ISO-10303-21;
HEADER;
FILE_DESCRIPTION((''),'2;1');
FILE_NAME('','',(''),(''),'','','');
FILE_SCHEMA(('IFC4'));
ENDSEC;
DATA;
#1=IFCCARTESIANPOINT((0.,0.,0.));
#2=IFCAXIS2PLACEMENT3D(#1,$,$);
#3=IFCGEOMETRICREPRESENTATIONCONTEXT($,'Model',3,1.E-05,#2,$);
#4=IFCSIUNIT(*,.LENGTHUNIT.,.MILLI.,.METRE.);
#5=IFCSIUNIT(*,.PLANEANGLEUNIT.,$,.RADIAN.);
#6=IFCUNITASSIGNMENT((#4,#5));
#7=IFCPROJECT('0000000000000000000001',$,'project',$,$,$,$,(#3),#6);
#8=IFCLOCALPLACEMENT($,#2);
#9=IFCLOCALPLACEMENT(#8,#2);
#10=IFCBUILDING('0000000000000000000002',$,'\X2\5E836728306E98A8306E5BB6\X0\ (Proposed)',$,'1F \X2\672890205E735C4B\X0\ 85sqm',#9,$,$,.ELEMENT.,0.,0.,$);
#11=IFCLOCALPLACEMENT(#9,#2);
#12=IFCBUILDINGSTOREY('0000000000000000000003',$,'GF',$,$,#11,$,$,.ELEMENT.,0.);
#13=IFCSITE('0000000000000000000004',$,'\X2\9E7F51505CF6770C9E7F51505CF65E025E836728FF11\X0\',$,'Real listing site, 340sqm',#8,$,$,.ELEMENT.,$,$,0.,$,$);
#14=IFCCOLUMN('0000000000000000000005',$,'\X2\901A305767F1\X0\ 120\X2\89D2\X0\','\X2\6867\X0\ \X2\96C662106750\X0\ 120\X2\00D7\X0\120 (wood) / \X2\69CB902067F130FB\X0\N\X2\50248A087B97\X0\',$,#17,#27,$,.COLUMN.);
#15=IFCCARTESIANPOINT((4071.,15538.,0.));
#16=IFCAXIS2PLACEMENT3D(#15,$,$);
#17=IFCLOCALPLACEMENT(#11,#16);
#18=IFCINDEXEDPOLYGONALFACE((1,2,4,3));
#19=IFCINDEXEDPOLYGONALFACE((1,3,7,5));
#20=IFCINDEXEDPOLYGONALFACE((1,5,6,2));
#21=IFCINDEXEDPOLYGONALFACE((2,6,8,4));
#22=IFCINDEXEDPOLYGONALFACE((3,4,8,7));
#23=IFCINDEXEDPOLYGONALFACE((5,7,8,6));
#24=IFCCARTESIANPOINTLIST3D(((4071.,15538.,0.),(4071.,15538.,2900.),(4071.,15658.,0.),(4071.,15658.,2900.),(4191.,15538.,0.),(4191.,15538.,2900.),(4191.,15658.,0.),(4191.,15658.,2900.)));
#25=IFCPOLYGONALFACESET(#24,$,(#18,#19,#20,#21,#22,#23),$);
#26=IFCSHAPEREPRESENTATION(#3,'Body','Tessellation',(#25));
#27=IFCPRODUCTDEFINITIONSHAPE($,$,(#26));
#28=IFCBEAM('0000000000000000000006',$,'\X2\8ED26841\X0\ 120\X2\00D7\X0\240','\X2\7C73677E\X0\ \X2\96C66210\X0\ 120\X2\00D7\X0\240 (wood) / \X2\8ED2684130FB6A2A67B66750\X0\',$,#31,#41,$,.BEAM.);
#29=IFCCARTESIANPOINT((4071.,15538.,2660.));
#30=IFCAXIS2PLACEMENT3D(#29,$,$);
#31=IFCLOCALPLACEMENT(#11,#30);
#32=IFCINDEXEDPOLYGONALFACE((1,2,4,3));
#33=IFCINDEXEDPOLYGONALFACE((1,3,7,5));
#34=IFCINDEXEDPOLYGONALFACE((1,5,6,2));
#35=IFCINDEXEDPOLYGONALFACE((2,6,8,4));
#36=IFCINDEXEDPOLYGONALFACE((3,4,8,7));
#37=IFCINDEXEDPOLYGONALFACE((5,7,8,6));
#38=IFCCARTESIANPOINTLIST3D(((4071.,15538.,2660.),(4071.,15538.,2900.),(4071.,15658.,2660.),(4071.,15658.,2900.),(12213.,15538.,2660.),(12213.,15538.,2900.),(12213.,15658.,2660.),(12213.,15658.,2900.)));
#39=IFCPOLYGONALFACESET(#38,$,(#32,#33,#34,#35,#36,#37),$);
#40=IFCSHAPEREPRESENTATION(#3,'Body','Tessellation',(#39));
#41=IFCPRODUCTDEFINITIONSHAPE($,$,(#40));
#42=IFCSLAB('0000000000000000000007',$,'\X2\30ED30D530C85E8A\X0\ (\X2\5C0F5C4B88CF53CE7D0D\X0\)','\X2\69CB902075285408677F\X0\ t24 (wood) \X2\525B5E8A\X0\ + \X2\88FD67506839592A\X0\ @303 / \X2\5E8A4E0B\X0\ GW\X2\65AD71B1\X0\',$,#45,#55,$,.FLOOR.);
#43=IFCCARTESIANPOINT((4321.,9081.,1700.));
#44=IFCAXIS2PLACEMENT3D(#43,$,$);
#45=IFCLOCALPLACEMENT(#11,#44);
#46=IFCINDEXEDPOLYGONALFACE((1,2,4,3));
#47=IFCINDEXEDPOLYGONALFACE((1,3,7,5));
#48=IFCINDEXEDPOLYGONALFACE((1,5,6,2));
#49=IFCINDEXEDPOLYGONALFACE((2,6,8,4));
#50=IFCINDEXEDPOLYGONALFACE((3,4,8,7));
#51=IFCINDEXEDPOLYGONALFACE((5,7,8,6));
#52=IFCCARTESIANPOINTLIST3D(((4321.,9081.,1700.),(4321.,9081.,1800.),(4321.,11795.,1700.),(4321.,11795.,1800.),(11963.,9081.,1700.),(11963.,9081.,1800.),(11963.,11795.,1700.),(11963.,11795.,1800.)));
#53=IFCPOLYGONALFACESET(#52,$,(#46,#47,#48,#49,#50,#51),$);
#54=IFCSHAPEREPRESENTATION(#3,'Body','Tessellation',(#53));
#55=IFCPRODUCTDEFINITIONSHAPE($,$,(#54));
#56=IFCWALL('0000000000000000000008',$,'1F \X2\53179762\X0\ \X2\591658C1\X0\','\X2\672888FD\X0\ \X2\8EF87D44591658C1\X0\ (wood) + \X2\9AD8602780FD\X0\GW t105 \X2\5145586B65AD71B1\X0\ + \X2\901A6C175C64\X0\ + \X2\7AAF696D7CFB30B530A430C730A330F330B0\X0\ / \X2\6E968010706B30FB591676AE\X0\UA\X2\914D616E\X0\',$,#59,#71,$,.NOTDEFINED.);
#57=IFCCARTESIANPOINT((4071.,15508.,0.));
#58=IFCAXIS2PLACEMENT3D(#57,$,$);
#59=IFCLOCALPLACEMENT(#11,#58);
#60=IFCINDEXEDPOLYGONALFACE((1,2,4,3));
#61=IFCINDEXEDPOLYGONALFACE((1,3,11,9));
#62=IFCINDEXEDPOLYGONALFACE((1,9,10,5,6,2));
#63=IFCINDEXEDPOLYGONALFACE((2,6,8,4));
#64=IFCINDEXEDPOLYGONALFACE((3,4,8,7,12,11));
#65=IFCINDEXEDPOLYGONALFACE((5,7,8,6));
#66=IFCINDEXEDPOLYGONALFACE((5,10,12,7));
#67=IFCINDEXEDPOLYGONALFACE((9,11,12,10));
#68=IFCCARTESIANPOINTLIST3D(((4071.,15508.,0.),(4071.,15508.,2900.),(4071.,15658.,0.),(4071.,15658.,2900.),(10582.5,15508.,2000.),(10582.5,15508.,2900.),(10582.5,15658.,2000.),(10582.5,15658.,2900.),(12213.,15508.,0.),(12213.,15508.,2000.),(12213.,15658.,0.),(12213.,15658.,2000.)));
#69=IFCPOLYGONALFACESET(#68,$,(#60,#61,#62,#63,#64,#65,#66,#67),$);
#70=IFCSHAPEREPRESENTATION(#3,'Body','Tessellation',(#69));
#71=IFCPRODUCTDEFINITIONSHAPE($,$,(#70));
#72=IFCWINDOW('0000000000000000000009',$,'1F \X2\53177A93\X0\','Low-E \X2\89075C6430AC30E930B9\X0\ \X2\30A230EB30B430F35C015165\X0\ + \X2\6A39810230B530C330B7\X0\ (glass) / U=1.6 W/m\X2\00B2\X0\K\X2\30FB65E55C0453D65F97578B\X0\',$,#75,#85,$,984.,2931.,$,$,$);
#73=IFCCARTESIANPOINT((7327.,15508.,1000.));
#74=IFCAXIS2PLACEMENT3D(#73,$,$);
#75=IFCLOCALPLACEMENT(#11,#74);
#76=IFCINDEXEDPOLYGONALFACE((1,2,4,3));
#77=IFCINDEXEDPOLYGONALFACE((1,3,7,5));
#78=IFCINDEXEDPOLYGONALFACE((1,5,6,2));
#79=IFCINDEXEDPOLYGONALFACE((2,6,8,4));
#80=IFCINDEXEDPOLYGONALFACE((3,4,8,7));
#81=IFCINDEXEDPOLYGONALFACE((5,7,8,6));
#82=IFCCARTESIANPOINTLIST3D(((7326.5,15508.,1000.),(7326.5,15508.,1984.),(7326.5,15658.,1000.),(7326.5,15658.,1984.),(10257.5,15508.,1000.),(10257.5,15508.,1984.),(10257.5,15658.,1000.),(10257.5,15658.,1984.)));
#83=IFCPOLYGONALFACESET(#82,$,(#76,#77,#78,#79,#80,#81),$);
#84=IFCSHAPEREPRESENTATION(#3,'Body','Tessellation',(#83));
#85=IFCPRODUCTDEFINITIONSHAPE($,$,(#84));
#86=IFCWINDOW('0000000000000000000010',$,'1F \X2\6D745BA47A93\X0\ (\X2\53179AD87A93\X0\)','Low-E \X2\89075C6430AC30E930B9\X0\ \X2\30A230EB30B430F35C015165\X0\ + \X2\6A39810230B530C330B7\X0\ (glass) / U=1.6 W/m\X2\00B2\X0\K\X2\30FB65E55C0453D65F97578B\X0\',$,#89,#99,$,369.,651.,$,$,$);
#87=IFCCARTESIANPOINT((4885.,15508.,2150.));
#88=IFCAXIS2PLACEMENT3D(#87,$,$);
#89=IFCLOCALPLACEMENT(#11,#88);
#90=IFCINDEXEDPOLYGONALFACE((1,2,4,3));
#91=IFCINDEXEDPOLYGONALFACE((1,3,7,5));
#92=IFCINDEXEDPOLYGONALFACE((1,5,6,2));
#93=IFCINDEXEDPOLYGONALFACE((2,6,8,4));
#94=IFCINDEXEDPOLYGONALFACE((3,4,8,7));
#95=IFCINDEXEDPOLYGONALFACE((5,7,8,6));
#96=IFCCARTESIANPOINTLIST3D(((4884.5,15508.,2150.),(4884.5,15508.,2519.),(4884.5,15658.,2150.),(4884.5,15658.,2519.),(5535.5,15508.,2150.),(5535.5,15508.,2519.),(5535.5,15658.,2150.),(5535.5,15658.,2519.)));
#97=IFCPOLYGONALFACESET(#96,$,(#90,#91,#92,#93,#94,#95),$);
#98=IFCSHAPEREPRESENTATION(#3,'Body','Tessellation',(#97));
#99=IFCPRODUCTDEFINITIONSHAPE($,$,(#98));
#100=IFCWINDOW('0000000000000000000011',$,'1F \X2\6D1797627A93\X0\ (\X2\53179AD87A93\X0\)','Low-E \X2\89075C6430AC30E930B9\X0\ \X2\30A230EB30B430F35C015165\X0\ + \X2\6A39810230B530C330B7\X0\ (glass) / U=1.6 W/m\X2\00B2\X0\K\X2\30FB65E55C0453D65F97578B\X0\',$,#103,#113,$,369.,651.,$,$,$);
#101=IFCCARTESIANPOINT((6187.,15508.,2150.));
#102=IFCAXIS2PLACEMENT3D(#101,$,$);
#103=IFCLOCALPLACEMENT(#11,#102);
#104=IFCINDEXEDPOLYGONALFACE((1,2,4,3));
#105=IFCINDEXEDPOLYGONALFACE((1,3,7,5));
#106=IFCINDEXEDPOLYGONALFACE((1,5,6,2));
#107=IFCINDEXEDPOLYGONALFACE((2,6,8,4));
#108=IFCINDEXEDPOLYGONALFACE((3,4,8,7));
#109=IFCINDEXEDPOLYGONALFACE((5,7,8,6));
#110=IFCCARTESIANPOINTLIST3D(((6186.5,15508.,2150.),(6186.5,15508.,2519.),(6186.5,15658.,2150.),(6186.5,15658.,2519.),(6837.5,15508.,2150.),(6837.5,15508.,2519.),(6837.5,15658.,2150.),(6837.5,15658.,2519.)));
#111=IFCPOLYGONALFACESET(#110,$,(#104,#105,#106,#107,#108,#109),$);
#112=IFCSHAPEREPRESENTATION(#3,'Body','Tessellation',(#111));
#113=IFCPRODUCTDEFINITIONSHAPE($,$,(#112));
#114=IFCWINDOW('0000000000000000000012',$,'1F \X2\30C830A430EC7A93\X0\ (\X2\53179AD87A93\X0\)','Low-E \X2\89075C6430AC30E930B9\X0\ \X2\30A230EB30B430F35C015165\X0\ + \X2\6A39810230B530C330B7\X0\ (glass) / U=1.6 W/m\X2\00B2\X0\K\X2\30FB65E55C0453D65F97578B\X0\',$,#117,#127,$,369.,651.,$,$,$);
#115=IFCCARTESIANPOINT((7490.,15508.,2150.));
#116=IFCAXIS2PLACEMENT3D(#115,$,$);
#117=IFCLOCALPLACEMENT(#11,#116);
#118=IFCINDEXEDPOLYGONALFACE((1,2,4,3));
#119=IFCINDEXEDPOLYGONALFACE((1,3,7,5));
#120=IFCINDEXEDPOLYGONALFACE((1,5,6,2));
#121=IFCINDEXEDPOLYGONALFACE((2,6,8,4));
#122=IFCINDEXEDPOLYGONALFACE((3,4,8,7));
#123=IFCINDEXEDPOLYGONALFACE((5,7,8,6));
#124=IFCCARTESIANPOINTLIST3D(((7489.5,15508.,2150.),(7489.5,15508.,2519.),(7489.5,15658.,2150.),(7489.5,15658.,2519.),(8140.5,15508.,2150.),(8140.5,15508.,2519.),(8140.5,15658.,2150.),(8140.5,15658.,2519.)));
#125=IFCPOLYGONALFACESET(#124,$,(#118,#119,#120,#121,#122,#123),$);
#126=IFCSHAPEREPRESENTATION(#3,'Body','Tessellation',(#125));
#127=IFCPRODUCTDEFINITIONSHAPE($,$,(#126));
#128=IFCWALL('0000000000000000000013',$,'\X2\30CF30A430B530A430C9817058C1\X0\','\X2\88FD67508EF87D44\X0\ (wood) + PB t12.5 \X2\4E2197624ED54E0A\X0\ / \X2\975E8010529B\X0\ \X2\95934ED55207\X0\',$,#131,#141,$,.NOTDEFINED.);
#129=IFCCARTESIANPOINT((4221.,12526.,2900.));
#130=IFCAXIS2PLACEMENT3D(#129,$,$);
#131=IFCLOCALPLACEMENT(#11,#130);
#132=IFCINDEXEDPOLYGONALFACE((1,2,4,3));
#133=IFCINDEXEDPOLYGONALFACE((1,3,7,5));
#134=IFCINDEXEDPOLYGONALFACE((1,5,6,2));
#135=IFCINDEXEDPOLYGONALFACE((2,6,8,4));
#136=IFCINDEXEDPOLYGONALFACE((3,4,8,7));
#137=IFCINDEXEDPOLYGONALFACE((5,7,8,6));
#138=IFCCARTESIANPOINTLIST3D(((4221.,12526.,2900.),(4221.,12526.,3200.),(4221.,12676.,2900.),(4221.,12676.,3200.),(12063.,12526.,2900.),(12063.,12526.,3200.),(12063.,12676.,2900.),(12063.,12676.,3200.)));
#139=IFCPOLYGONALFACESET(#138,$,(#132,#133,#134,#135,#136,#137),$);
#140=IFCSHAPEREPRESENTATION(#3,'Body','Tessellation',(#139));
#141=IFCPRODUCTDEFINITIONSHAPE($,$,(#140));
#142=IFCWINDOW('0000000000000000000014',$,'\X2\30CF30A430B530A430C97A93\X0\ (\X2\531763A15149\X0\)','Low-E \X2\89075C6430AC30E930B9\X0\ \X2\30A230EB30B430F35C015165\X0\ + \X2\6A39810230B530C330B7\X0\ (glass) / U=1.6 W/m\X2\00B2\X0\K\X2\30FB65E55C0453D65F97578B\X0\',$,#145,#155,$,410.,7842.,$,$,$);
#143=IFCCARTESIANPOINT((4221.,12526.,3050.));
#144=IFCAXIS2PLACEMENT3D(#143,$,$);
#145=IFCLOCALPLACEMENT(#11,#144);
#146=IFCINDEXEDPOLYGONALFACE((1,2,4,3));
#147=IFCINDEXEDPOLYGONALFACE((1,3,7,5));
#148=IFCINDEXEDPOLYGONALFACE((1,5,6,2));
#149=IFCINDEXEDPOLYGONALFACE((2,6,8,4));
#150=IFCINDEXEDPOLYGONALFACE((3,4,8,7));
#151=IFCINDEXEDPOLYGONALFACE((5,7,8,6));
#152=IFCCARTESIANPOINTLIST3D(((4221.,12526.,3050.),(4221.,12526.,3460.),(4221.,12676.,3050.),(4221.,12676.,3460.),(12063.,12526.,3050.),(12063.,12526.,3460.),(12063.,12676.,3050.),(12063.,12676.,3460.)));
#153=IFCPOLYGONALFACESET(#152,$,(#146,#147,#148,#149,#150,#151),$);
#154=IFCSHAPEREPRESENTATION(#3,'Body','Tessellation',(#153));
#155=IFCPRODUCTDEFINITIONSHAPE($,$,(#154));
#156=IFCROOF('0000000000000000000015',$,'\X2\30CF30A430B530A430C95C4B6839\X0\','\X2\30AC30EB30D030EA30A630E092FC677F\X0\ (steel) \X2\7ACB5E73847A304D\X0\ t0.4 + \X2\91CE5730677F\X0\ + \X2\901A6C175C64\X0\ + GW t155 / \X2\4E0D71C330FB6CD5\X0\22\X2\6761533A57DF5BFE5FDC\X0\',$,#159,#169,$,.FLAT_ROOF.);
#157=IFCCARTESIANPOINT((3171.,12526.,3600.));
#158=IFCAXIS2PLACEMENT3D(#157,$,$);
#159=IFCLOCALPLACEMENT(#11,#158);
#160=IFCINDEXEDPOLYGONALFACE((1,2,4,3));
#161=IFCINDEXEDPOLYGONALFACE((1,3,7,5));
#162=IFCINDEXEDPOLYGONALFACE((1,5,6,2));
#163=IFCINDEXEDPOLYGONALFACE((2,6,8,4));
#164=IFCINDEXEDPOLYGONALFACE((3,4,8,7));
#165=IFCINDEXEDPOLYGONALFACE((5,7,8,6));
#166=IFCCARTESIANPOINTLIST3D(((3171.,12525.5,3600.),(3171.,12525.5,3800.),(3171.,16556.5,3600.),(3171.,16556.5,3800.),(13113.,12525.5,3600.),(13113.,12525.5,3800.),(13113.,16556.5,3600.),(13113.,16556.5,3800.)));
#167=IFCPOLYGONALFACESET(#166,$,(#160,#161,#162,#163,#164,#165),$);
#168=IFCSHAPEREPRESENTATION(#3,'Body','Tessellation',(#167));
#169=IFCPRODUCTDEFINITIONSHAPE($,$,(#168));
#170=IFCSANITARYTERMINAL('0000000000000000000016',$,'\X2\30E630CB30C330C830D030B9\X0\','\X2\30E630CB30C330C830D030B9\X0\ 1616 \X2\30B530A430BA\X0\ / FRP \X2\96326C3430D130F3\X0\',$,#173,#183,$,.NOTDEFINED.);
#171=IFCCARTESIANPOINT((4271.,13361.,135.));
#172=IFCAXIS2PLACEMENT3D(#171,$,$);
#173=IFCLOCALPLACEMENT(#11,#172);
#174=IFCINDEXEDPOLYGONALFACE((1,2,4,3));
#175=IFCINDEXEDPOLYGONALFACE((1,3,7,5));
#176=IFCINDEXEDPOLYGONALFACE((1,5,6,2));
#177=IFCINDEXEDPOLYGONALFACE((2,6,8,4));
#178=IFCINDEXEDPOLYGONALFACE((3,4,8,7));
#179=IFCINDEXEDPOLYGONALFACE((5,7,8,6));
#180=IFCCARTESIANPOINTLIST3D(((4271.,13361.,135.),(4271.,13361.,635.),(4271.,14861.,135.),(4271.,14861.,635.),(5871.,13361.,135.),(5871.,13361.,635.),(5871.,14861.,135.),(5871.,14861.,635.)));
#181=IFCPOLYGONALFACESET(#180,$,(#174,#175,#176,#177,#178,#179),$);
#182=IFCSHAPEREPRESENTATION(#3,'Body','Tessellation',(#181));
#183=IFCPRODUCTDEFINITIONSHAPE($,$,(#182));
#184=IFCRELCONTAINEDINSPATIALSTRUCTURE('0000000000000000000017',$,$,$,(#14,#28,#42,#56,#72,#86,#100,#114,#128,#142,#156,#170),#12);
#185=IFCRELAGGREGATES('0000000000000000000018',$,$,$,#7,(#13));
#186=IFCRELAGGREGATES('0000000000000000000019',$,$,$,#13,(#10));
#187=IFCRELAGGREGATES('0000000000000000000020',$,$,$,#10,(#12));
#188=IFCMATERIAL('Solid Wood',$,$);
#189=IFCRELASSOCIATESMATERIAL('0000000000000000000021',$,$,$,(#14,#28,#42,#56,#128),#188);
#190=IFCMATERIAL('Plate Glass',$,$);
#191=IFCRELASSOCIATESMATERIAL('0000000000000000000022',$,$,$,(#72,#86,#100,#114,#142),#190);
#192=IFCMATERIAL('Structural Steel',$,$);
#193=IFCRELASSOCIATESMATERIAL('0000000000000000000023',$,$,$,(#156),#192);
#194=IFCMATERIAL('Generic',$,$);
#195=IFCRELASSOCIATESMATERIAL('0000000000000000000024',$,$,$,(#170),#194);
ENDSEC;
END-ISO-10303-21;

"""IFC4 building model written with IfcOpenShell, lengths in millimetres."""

from ifc_helpers import new_model, si_unit, frame, frame_2d, origin, place, context, project, spatial, rectangle, extrude, material, element, fill, save


model = new_model("IFC4")

# Units and contexts
model_context = context("Model", 3, precision=1e-05, world=origin())
ifc_project = project(units=[si_unit("LENGTHUNIT", "METRE", prefix="MILLI"), si_unit("PLANEANGLEUNIT", "RADIAN")], contexts=[model_context])

# Site, building, storey
site_placement = place(None, origin())
site = spatial("IfcSite", under=ifc_project, at=site_placement, Name="鹿児島県鹿児島市広木１", ObjectType="Real listing site, 340sqm", CompositionType="ELEMENT", RefElevation=0.0)
building_placement = place(site_placement, origin())
building = spatial("IfcBuilding", under=site, at=building_placement, Name="広木の風の家 (Proposed)", ObjectType="1F 木造平屋 85sqm", CompositionType="ELEMENT", ElevationOfRefHeight=0.0, ElevationOfTerrain=0.0)
storey_placement = place(building_placement, origin())
storey = spatial("IfcBuildingStorey", under=building, at=storey_placement, Name="GF", CompositionType="ELEMENT", Elevation=0.0)

# Column
ifc_material_1 = material(Name="Solid Wood")
column_1_placement = place(storey_placement, frame((4071.0, 15538.0, 0.0)))
element("IfcColumn", 1, at=column_1_placement, inside=storey, material=ifc_material_1, Name="通し柱 120角", Description="桧 集成材 120×120 (wood) / 構造柱・N値計算", PredefinedType="COLUMN", context=model_context, shape_type="SweptSolid", body=[
    extrude(rectangle(XDim=120.0, YDim=120.0, at=frame_2d((60.0, 60.0))), frame((4071.0, 15538.0, 0.0)), (0.0, 0.0, 1.0), 2900.0),
])

# Beam
beam_1_placement = place(storey_placement, frame((4071.0, 15538.0, 2660.0)))
element("IfcBeam", 2, at=beam_1_placement, inside=storey, material=ifc_material_1, Name="軒桁 120×240", Description="米松 集成 120×240 (wood) / 軒桁・横架材", PredefinedType="BEAM", context=model_context, shape_type="SweptSolid", body=[
    extrude(rectangle(XDim=8142.0, YDim=120.0, at=frame_2d((4071.0, 60.0))), frame((4071.0, 15538.0, 2660.0)), (0.0, 0.0, 1.0), 240.0),
])

# Slab
slab_placement = place(storey_placement, frame((4321.0, 9081.0, 1700.0)))
element("IfcSlab", 3, at=slab_placement, inside=storey, material=ifc_material_1, Name="ロフト床 (小屋裏収納)", Description="構造用合板 t24 (wood) 剛床 + 製材根太 @303 / 床下 GW断熱", PredefinedType="FLOOR", context=model_context, shape_type="SweptSolid", body=[
    extrude(rectangle(XDim=7642.0, YDim=2714.0, at=frame_2d((3821.0, 1357.0))), frame((4321.0, 9081.0, 1700.0)), (0.0, 0.0, 1.0), 100.0),
])

# Wall, openings, windows
wall_1_placement = place(storey_placement, frame((4071.0, 15508.0, 0.0)))
wall_1 = element("IfcWall", 4, at=wall_1_placement, inside=storey, material=ifc_material_1, Name="1F 北面 外壁", Description="木製 軸組外壁 (wood) + 高性能GW t105 充填断熱 + 通気層 + 窯業系サイディング / 準耐火・外皮UA配慮", PredefinedType="NOTDEFINED", context=model_context, shape_type="SweptSolid", body=[
    extrude(rectangle(XDim=8142.0, YDim=150.0, at=frame_2d((4071.0, 75.0))), frame((4071.0, 15508.0, 0.0)), (0.0, 0.0, 1.0), 2900.0),
])
opening_1_placement = place(storey_placement, frame((7327.0, 15508.0, 1000.0)))
opening_1 = element("IfcOpeningElement", 5, at=opening_1_placement, cuts=wall_1, PredefinedType="NOTDEFINED", context=model_context, shape_type="SweptSolid", body=[
    extrude(rectangle(XDim=2931.0, YDim=150.0, at=frame_2d((1465.0, 75.0))), frame((7327.0, 15508.0, 1000.0)), (0.0, 0.0, 1.0), 984.0),
])
opening_2_placement = place(storey_placement, frame((4885.0, 15508.0, 2150.0)))
opening_2 = element("IfcOpeningElement", 6, at=opening_2_placement, cuts=wall_1, PredefinedType="NOTDEFINED", context=model_context, shape_type="SweptSolid", body=[
    extrude(rectangle(XDim=651.0, YDim=150.0, at=frame_2d((325.0, 75.0))), frame((4885.0, 15508.0, 2150.0)), (0.0, 0.0, 1.0), 369.0),
])
opening_3_placement = place(storey_placement, frame((6187.0, 15508.0, 2150.0)))
opening_3 = element("IfcOpeningElement", 7, at=opening_3_placement, cuts=wall_1, PredefinedType="NOTDEFINED", context=model_context, shape_type="SweptSolid", body=[
    extrude(rectangle(XDim=651.0, YDim=150.0, at=frame_2d((325.0, 75.0))), frame((6187.0, 15508.0, 2150.0)), (0.0, 0.0, 1.0), 369.0),
])
opening_4_placement = place(storey_placement, frame((7490.0, 15508.0, 2150.0)))
opening_4 = element("IfcOpeningElement", 8, at=opening_4_placement, cuts=wall_1, PredefinedType="NOTDEFINED", context=model_context, shape_type="SweptSolid", body=[
    extrude(rectangle(XDim=651.0, YDim=150.0, at=frame_2d((325.0, 75.0))), frame((7490.0, 15508.0, 2150.0)), (0.0, 0.0, 1.0), 369.0),
])
ifc_material_2 = material(Name="Plate Glass")
window_1_placement = place(storey_placement, frame((7327.0, 15508.0, 1000.0)))
window_1 = element("IfcWindow", 9, at=window_1_placement, inside=storey, material=ifc_material_2, Name="1F 北窓", Description="Low-E 複層ガラス アルゴン封入 + 樹脂サッシ (glass) / U=1.6 W/m²K・日射取得型", OverallHeight=984.0, OverallWidth=2931.0, context=model_context, shape_type="SweptSolid", body=[
    extrude(rectangle(XDim=2931.0, YDim=150.0, at=frame_2d((1465.0, 75.0))), frame((7327.0, 15508.0, 1000.0)), (0.0, 0.0, 1.0), 984.0),
])
fill(opening_1, window_1)
window_2_placement = place(storey_placement, frame((4885.0, 15508.0, 2150.0)))
window_2 = element("IfcWindow", 10, at=window_2_placement, inside=storey, material=ifc_material_2, Name="1F 浴室窓 (北高窓)", Description="Low-E 複層ガラス アルゴン封入 + 樹脂サッシ (glass) / U=1.6 W/m²K・日射取得型", OverallHeight=369.0, OverallWidth=651.0, context=model_context, shape_type="SweptSolid", body=[
    extrude(rectangle(XDim=651.0, YDim=150.0, at=frame_2d((325.0, 75.0))), frame((4885.0, 15508.0, 2150.0)), (0.0, 0.0, 1.0), 369.0),
])
fill(opening_2, window_2)
window_3_placement = place(storey_placement, frame((6187.0, 15508.0, 2150.0)))
window_3 = element("IfcWindow", 11, at=window_3_placement, inside=storey, material=ifc_material_2, Name="1F 洗面窓 (北高窓)", Description="Low-E 複層ガラス アルゴン封入 + 樹脂サッシ (glass) / U=1.6 W/m²K・日射取得型", OverallHeight=369.0, OverallWidth=651.0, context=model_context, shape_type="SweptSolid", body=[
    extrude(rectangle(XDim=651.0, YDim=150.0, at=frame_2d((325.0, 75.0))), frame((6187.0, 15508.0, 2150.0)), (0.0, 0.0, 1.0), 369.0),
])
fill(opening_3, window_3)
window_4_placement = place(storey_placement, frame((7490.0, 15508.0, 2150.0)))
window_4 = element("IfcWindow", 12, at=window_4_placement, inside=storey, material=ifc_material_2, Name="1F トイレ窓 (北高窓)", Description="Low-E 複層ガラス アルゴン封入 + 樹脂サッシ (glass) / U=1.6 W/m²K・日射取得型", OverallHeight=369.0, OverallWidth=651.0, context=model_context, shape_type="SweptSolid", body=[
    extrude(rectangle(XDim=651.0, YDim=150.0, at=frame_2d((325.0, 75.0))), frame((7490.0, 15508.0, 2150.0)), (0.0, 0.0, 1.0), 369.0),
])
fill(opening_4, window_4)

# Wall, opening, window
wall_2_placement = place(storey_placement, frame((4221.0, 12526.0, 2900.0)))
wall_2 = element("IfcWall", 13, at=wall_2_placement, inside=storey, material=ifc_material_1, Name="ハイサイド腰壁", Description="製材軸組 (wood) + PB t12.5 両面仕上 / 非耐力 間仕切", PredefinedType="NOTDEFINED", context=model_context, shape_type="SweptSolid", body=[
    extrude(rectangle(XDim=7842.0, YDim=150.0, at=frame_2d((3921.0, 75.0))), frame((4221.0, 12526.0, 2900.0)), (0.0, 0.0, 1.0), 700.0),
])
opening_5_placement = place(storey_placement, frame((4221.0, 12526.0, 3050.0)))
opening_5 = element("IfcOpeningElement", 14, at=opening_5_placement, cuts=wall_2, PredefinedType="NOTDEFINED", context=model_context, shape_type="SweptSolid", body=[
    extrude(rectangle(XDim=7842.0, YDim=150.0, at=frame_2d((3921.0, 75.0))), frame((4221.0, 12526.0, 3050.0)), (0.0, 0.0, 1.0), 410.0),
])
window_5_placement = place(storey_placement, frame((4221.0, 12526.0, 3050.0)))
window_5 = element("IfcWindow", 15, at=window_5_placement, inside=storey, material=ifc_material_2, Name="ハイサイド窓 (北採光)", Description="Low-E 複層ガラス アルゴン封入 + 樹脂サッシ (glass) / U=1.6 W/m²K・日射取得型", OverallHeight=410.0, OverallWidth=7842.0, context=model_context, shape_type="SweptSolid", body=[
    extrude(rectangle(XDim=7842.0, YDim=150.0, at=frame_2d((3921.0, 75.0))), frame((4221.0, 12526.0, 3050.0)), (0.0, 0.0, 1.0), 410.0),
])
fill(opening_5, window_5)

# Roof
ifc_material_3 = material(Name="Structural Steel")
roof_placement = place(storey_placement, frame((3171.0, 12526.0, 3600.0)))
element("IfcRoof", 16, at=roof_placement, inside=storey, material=ifc_material_3, Name="ハイサイド屋根", Description="ガルバリウム鋼板 (steel) 立平葺き t0.4 + 野地板 + 通気層 + GW t155 / 不燃・法22条区域対応", PredefinedType="FLAT_ROOF", context=model_context, shape_type="SweptSolid", body=[
    extrude(rectangle(XDim=9942.0, YDim=4031.0, at=frame_2d((4971.0, 2015.0))), frame((3171.0, 12526.0, 3600.0)), (0.0, 0.0, 1.0), 200.0),
])

# Sanitary terminal
ifc_material_4 = material(Name="Generic")
sanitary_terminal_placement = place(storey_placement, frame((4271.0, 13361.0, 135.0)))
element("IfcSanitaryTerminal", 17, at=sanitary_terminal_placement, inside=storey, material=ifc_material_4, Name="ユニットバス", Description="ユニットバス 1616 サイズ / FRP 防水パン", PredefinedType="NOTDEFINED", context=model_context, shape_type="SweptSolid", body=[
    extrude(rectangle(XDim=1600.0, YDim=1500.0, at=frame_2d((800.0, 750.0))), frame((4271.0, 13361.0, 135.0)), (0.0, 0.0, 1.0), 500.0),
])

save(model, "model.ifc")
